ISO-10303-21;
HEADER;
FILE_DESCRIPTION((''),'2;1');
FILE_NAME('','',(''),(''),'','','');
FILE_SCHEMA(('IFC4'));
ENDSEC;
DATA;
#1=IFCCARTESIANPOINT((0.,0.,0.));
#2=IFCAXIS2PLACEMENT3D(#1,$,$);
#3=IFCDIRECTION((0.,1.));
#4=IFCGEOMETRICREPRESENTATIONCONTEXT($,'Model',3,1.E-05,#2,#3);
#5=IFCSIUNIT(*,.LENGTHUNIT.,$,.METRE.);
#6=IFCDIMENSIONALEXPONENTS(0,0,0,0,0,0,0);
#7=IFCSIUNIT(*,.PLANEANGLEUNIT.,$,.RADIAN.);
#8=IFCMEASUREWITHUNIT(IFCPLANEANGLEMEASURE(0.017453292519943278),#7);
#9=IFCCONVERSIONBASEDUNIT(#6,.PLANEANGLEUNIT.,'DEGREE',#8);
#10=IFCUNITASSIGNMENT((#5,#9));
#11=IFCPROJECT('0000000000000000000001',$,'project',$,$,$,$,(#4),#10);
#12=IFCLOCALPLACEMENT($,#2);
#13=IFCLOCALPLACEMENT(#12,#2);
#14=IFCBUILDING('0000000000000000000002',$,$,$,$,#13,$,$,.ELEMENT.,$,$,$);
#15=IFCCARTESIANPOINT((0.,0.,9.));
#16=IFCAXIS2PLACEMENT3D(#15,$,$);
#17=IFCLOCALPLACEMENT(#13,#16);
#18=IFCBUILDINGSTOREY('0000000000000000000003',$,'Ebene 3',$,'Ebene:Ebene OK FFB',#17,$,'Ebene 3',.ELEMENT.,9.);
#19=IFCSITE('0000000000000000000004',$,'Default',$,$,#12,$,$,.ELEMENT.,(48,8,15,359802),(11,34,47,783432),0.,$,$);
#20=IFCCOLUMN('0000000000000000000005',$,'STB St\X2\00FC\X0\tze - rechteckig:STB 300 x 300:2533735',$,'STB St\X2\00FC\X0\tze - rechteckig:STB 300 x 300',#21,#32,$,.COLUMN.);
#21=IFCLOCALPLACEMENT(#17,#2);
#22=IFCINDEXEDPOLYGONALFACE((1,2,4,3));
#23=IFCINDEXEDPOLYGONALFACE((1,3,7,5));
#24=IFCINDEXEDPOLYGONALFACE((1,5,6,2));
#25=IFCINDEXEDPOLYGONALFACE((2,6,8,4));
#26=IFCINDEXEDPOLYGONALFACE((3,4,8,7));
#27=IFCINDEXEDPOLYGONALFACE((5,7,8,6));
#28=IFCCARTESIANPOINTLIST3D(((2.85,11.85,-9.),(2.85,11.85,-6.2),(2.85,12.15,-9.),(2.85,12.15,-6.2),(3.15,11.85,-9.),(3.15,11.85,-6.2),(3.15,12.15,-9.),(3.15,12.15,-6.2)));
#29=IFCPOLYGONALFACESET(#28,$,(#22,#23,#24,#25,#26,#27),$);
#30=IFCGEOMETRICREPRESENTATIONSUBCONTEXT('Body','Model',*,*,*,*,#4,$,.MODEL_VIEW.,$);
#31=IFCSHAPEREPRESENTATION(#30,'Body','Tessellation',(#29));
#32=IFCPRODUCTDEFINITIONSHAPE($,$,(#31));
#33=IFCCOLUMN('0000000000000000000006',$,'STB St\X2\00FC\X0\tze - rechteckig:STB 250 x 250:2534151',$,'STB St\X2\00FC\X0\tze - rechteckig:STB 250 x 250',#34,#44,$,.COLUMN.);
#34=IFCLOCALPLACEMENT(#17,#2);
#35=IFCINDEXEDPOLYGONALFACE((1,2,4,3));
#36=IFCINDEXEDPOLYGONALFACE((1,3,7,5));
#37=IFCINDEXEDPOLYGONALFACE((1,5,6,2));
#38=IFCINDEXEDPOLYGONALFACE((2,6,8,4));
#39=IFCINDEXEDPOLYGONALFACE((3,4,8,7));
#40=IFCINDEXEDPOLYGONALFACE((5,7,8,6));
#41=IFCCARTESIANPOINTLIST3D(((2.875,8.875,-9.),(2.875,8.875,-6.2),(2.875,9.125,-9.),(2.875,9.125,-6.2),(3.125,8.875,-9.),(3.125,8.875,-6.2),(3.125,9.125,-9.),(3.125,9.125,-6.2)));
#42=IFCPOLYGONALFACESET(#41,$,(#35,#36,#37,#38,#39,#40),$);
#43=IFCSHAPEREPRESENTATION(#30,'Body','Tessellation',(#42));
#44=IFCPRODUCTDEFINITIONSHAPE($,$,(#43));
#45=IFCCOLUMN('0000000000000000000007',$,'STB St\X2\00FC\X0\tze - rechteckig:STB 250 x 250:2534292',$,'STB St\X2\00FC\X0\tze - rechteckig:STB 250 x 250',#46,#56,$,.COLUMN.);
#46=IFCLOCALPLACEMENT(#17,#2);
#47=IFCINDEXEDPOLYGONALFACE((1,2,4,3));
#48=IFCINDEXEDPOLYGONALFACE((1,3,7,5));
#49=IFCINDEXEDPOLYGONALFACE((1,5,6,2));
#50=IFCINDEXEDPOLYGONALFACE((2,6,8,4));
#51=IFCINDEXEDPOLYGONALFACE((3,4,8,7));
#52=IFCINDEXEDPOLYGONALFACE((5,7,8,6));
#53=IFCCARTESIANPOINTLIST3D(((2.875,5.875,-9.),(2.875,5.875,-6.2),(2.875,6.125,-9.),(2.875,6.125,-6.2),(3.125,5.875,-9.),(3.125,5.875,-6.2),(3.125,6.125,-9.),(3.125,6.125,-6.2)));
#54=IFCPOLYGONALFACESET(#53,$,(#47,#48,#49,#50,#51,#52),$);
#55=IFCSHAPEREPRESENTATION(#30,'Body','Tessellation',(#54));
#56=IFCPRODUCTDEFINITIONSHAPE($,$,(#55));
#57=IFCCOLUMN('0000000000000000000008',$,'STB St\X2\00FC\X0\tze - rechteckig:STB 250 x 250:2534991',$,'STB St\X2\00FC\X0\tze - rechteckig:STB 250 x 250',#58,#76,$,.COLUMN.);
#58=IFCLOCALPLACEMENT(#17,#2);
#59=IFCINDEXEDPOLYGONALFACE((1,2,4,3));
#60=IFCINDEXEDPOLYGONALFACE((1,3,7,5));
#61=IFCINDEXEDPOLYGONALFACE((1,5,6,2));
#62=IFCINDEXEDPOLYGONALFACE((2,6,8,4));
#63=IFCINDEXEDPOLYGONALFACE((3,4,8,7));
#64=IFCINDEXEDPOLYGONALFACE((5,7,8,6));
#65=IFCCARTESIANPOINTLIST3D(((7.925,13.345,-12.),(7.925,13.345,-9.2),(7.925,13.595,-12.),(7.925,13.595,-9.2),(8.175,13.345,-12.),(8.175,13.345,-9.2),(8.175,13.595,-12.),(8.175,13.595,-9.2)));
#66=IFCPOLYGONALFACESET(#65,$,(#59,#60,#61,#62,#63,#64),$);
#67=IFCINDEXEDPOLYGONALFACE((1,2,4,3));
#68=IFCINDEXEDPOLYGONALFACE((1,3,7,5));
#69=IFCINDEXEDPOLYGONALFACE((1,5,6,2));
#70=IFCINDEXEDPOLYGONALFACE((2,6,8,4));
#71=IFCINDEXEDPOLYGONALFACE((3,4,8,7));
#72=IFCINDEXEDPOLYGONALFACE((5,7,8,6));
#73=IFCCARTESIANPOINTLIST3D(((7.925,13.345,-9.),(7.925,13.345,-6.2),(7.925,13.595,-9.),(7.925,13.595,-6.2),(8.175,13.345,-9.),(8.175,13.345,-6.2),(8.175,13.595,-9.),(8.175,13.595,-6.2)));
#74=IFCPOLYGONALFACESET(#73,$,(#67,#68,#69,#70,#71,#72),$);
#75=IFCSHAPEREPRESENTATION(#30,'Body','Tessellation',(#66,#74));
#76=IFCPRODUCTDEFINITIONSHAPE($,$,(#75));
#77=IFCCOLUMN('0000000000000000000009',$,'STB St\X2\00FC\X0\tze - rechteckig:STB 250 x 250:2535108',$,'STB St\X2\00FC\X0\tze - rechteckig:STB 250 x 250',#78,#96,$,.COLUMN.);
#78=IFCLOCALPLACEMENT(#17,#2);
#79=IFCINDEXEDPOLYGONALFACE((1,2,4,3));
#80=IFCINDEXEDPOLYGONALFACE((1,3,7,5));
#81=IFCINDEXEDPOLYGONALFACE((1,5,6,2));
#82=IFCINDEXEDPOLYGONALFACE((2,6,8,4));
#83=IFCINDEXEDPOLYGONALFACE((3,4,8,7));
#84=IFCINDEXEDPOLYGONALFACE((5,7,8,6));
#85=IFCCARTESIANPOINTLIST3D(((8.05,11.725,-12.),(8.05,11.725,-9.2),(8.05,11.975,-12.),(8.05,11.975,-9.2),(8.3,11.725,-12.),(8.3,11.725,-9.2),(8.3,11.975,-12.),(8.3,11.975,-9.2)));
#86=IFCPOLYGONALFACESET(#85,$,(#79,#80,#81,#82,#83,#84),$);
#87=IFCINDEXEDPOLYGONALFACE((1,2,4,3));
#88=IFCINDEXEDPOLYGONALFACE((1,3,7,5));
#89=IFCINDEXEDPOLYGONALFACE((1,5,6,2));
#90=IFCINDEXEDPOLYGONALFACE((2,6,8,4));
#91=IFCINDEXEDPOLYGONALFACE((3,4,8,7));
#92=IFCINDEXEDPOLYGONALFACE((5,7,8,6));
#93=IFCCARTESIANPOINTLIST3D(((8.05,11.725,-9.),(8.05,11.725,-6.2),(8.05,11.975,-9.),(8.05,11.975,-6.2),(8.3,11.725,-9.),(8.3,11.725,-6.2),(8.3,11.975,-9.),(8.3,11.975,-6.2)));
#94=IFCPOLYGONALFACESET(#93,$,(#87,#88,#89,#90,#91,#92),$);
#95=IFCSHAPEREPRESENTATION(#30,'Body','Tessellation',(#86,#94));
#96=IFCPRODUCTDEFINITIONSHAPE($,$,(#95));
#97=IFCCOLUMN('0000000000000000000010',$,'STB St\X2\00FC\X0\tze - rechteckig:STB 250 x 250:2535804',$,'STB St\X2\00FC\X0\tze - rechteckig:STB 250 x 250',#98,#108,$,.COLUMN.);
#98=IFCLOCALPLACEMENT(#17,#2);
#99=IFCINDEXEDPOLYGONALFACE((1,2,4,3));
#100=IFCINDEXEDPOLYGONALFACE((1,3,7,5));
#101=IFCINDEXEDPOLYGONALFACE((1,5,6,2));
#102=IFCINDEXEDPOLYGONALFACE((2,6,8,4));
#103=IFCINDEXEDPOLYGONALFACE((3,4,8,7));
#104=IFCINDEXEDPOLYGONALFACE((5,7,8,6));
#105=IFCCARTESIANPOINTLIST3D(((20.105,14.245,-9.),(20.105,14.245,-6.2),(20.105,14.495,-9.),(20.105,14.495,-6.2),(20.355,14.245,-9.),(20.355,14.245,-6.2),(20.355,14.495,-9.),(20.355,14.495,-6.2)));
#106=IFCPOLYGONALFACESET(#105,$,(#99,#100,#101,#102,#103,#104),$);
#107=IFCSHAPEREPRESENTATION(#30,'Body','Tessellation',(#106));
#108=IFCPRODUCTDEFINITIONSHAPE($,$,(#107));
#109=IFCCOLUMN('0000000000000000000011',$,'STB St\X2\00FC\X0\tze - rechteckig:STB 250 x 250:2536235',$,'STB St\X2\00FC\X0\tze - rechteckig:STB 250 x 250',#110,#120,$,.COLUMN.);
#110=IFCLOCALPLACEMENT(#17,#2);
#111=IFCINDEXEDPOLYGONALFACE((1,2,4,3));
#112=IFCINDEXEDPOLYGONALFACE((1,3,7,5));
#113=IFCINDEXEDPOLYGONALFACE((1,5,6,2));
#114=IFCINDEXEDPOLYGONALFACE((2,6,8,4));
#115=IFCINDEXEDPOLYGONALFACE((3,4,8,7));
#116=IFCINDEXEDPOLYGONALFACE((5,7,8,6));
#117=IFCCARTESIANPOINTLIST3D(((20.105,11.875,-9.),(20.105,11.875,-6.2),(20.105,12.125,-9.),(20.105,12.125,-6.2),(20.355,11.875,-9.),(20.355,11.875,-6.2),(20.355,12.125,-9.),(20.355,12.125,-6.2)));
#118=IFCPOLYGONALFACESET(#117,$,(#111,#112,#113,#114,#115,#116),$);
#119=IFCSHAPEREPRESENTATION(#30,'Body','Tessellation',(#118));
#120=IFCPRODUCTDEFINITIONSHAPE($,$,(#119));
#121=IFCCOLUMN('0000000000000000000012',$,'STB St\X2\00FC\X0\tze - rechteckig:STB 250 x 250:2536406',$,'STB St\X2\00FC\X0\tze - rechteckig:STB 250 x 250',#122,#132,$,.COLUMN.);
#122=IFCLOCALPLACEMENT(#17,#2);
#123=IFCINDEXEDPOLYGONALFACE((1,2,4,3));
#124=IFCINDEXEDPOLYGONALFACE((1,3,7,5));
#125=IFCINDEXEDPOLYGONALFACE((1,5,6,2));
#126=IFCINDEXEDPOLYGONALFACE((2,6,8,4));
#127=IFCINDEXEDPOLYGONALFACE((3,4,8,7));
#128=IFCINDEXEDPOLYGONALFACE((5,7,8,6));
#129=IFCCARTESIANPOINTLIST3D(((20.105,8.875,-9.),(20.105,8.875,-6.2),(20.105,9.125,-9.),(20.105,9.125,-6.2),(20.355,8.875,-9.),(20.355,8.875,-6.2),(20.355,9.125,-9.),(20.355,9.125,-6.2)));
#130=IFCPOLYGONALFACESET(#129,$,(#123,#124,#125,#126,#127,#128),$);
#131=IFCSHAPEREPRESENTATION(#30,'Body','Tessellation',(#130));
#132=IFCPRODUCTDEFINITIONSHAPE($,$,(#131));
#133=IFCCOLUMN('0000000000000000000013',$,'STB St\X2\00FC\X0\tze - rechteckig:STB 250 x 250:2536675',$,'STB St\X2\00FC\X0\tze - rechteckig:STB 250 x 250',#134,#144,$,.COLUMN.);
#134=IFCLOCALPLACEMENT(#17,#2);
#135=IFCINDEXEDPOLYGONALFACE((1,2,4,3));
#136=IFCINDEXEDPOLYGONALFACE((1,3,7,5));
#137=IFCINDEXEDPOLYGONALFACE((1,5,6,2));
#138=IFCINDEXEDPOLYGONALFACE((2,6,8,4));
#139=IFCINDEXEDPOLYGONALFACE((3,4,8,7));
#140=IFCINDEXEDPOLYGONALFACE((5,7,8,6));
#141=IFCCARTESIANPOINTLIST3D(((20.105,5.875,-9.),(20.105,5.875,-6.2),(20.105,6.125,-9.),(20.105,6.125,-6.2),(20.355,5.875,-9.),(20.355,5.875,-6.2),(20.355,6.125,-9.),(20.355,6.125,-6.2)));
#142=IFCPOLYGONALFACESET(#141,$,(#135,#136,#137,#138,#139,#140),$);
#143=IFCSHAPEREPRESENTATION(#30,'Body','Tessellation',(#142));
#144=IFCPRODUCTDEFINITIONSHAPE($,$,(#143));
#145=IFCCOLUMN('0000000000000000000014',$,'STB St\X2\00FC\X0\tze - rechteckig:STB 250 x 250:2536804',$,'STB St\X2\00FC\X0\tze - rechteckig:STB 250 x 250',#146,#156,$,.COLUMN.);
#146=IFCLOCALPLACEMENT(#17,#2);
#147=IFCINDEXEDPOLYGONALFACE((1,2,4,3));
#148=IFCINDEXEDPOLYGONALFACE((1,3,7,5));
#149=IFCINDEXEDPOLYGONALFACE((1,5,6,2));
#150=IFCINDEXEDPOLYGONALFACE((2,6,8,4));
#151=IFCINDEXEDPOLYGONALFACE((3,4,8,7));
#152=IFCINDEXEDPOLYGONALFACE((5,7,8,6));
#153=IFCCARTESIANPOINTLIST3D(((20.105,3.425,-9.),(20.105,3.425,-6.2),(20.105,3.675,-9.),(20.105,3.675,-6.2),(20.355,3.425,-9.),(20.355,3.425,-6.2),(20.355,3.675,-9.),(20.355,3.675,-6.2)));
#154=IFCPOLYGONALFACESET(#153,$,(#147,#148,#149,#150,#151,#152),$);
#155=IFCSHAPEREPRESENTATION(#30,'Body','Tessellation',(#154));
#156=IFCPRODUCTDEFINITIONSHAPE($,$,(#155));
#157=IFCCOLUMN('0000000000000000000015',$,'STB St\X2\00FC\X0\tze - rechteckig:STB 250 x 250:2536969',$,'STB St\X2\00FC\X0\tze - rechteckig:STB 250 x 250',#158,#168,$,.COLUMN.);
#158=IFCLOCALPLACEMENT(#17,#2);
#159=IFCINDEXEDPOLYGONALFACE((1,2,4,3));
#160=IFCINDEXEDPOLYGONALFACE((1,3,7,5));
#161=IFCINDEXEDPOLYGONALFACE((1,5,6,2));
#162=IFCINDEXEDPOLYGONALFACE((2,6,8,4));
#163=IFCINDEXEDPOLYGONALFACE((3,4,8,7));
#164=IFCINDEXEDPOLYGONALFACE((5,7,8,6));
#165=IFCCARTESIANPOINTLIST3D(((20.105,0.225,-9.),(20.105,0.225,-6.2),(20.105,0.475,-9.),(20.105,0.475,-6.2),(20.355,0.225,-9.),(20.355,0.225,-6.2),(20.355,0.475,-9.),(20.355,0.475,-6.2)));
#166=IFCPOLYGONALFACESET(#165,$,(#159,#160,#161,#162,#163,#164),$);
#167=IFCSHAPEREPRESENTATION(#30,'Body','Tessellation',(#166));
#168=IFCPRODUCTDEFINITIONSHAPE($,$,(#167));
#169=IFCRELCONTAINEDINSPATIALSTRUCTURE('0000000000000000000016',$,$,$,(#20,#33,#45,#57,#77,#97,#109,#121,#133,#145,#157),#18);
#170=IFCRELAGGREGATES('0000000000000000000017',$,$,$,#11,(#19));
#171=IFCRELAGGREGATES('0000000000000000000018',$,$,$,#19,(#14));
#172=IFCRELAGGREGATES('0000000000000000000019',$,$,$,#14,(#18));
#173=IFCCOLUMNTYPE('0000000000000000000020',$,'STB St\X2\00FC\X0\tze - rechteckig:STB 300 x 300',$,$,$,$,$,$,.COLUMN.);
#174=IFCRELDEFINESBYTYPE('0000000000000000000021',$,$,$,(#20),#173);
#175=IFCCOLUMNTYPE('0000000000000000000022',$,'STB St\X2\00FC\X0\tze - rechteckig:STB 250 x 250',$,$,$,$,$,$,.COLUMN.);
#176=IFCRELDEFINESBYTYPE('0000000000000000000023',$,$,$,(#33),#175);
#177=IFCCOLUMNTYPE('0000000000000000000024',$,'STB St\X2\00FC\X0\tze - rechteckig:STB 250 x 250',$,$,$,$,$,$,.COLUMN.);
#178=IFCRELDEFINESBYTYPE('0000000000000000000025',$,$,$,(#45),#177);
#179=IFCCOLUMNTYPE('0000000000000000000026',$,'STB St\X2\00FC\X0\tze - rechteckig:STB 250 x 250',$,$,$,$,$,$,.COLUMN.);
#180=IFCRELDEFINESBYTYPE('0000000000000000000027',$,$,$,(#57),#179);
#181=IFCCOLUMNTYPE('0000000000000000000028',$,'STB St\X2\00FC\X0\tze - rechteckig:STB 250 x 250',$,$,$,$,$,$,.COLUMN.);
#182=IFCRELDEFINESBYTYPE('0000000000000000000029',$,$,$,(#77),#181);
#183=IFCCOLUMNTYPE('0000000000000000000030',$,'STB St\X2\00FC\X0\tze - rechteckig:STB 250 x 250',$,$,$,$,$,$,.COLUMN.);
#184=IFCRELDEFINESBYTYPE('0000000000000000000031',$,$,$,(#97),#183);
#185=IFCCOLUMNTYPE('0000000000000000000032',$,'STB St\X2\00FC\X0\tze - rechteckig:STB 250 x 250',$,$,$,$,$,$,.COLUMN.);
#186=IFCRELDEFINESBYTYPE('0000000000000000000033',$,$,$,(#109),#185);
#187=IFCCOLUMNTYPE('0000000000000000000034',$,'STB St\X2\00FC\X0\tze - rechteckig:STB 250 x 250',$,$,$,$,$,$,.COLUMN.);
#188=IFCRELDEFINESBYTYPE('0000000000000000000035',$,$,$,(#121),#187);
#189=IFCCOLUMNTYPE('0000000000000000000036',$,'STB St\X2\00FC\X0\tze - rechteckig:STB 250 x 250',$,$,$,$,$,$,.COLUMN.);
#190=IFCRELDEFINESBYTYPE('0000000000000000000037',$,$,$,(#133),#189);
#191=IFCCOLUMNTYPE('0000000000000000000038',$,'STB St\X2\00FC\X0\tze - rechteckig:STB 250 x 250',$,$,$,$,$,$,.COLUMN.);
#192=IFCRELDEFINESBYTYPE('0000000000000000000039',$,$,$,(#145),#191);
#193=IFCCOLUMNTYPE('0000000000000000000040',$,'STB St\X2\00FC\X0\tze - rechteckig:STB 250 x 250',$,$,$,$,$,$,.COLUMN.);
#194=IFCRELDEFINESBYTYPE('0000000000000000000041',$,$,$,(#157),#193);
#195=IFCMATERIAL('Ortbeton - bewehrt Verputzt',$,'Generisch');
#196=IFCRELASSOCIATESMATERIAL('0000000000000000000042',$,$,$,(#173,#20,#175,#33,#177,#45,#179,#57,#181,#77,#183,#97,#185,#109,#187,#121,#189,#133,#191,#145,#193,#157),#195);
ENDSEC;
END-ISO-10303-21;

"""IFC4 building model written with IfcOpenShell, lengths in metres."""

from ifc_helpers import new_model, entity, si_unit, converted_unit, direction, frame, origin, place, context, subcontext, project, spatial, indexed_curve, outline, extrude, source, transform, mapped, material, type_object, type_shapes, element, save


model = new_model("IFC4")

# Units and contexts
model_context = context("Model", 3, precision=1e-05, world=origin(), true_north=direction((0.0, 1.0)))
body_context = subcontext(model_context, "Body", "Model", "MODEL_VIEW")
ifc_project = project(units=[si_unit("LENGTHUNIT", "METRE"), converted_unit("PLANEANGLEUNIT", "DEGREE", entity("IfcPlaneAngleMeasure", 0.017453292519943278), si_unit("PLANEANGLEUNIT", "RADIAN"), dimensions=[0, 0, 0, 0, 0, 0, 0])], contexts=[model_context])

# Site, building, storey
site_placement = place(None, origin())
site = spatial("IfcSite", under=ifc_project, at=site_placement, Name="Default", CompositionType="ELEMENT", RefLatitude=(48, 8, 15, 359802), RefLongitude=(11, 34, 47, 783432), RefElevation=0.0)
building_placement = place(site_placement, origin())
building = spatial("IfcBuilding", under=site, at=building_placement, CompositionType="ELEMENT")
storey_placement = place(building_placement, frame((0.0, 0.0, 9.0)))
storey = spatial("IfcBuildingStorey", under=building, at=storey_placement, Name="Ebene 3", ObjectType="Ebene:Ebene OK FFB", LongName="Ebene 3", CompositionType="ELEMENT", Elevation=9.0)

# Columns
ifc_material_1 = material(Name="Ortbeton - bewehrt Verputzt", Category="Generisch")
column_type_1 = type_object("IfcColumnType", Name="STB Stütze - rechteckig:STB 300 x 300", PredefinedType="COLUMN", material=ifc_material_1)
shared_shape_1 = source(origin(), body_context, "Body", "SweptSolid", [
    extrude(outline(indexed_curve([(-0.15, -0.15), (0.15, -0.15), (0.15, 0.15), (-0.15, 0.15), (-0.15, -0.15)], self_intersect=False)), frame((3.0, 12.0, 0.0), z_axis=(0.0, 0.0, 1.0), x_axis=(-1.0, 0.0, 0.0)), (0.0, 0.0, 1.0), 2.8),
])
type_shapes(column_type_1, [shared_shape_1])
column_1_placement = place(storey_placement, frame((0.0, 0.0, -9.0)))
element("IfcColumn", 1, at=column_1_placement, inside=storey, type_object=column_type_1, material=ifc_material_1, Name="STB Stütze - rechteckig:STB 300 x 300:2533735", ObjectType="STB Stütze - rechteckig:STB 300 x 300", PredefinedType="COLUMN", context=body_context, shape_type="MappedRepresentation", body=[
    mapped(shared_shape_1, transform((0.0, 0.0, 0.0), scale=1.0)),
])
column_type_2 = type_object("IfcColumnType", Name="STB Stütze - rechteckig:STB 250 x 250", PredefinedType="COLUMN", material=ifc_material_1)
shared_shape_2 = source(origin(), body_context, "Body", "SweptSolid", [
    extrude(outline(indexed_curve([(-0.125, -0.125), (0.125, -0.125), (0.125, 0.125), (-0.125, 0.125), (-0.125, -0.125)], self_intersect=False)), frame((3.0, 9.0, 0.0), z_axis=(0.0, 0.0, 1.0), x_axis=(-1.0, 0.0, 0.0)), (0.0, 0.0, 1.0), 2.8),
])
type_shapes(column_type_2, [shared_shape_2])
column_2_placement = place(storey_placement, frame((0.0, 0.0, -9.0)))
element("IfcColumn", 2, at=column_2_placement, inside=storey, type_object=column_type_2, material=ifc_material_1, Name="STB Stütze - rechteckig:STB 250 x 250:2534151", ObjectType="STB Stütze - rechteckig:STB 250 x 250", PredefinedType="COLUMN", context=body_context, shape_type="MappedRepresentation", body=[
    mapped(shared_shape_2, transform((0.0, 0.0, 0.0), scale=1.0)),
])
column_type_3 = type_object("IfcColumnType", Name="STB Stütze - rechteckig:STB 250 x 250", PredefinedType="COLUMN", material=ifc_material_1)
shared_shape_3 = source(origin(), body_context, "Body", "SweptSolid", [
    extrude(outline(indexed_curve([(-0.125, -0.125), (0.125, -0.125), (0.125, 0.125), (-0.125, 0.125), (-0.125, -0.125)], self_intersect=False)), frame((3.0, 6.0, 0.0), z_axis=(0.0, 0.0, 1.0), x_axis=(-1.0, 0.0, 0.0)), (0.0, 0.0, 1.0), 2.8),
])
type_shapes(column_type_3, [shared_shape_3])
column_3_placement = place(storey_placement, frame((0.0, 0.0, -9.0)))
element("IfcColumn", 3, at=column_3_placement, inside=storey, type_object=column_type_3, material=ifc_material_1, Name="STB Stütze - rechteckig:STB 250 x 250:2534292", ObjectType="STB Stütze - rechteckig:STB 250 x 250", PredefinedType="COLUMN", context=body_context, shape_type="MappedRepresentation", body=[
    mapped(shared_shape_3, transform((0.0, 0.0, 0.0), scale=1.0)),
])
column_type_4 = type_object("IfcColumnType", Name="STB Stütze - rechteckig:STB 250 x 250", PredefinedType="COLUMN", material=ifc_material_1)
shared_shape_4 = source(origin(), body_context, "Body", "SweptSolid", [
    extrude(outline(indexed_curve([(-0.125, -0.125), (0.125, -0.125), (0.125, 0.125), (-0.125, 0.125), (-0.125, -0.125)], self_intersect=False)), frame((8.05, 13.47, -3.0), z_axis=(0.0, 0.0, 1.0), x_axis=(-1.0, 0.0, 0.0)), (0.0, 0.0, 1.0), 2.8),
    extrude(outline(indexed_curve([(-0.125, -0.125), (0.125, -0.125), (0.125, 0.125), (-0.125, 0.125), (-0.125, -0.125)], self_intersect=False)), frame((8.05, 13.47, 0.0), z_axis=(0.0, 0.0, 1.0), x_axis=(0.0, -1.0, 0.0)), (0.0, 0.0, 1.0), 2.8),
])
type_shapes(column_type_4, [shared_shape_4])
column_4_placement = place(storey_placement, frame((0.0, 0.0, -9.0)))
element("IfcColumn", 4, at=column_4_placement, inside=storey, type_object=column_type_4, material=ifc_material_1, Name="STB Stütze - rechteckig:STB 250 x 250:2534991", ObjectType="STB Stütze - rechteckig:STB 250 x 250", PredefinedType="COLUMN", context=body_context, shape_type="MappedRepresentation", body=[
    mapped(shared_shape_4, transform((0.0, 0.0, 0.0), scale=1.0)),
])
column_type_5 = type_object("IfcColumnType", Name="STB Stütze - rechteckig:STB 250 x 250", PredefinedType="COLUMN", material=ifc_material_1)
shared_shape_5 = source(origin(), body_context, "Body", "SweptSolid", [
    extrude(outline(indexed_curve([(-0.125, -0.125), (0.125, -0.125), (0.125, 0.125), (-0.125, 0.125), (-0.125, -0.125)], self_intersect=False)), frame((8.175, 11.85, -3.0), z_axis=(0.0, 0.0, 1.0), x_axis=(-1.0, 0.0, 0.0)), (0.0, 0.0, 1.0), 2.8),
    extrude(outline(indexed_curve([(-0.125, -0.125), (0.125, -0.125), (0.125, 0.125), (-0.125, 0.125), (-0.125, -0.125)], self_intersect=False)), frame((8.175, 11.85, 0.0), z_axis=(0.0, 0.0, 1.0), x_axis=(0.0, -1.0, 0.0)), (0.0, 0.0, 1.0), 2.8),
])
type_shapes(column_type_5, [shared_shape_5])
column_5_placement = place(storey_placement, frame((0.0, 0.0, -9.0)))
element("IfcColumn", 5, at=column_5_placement, inside=storey, type_object=column_type_5, material=ifc_material_1, Name="STB Stütze - rechteckig:STB 250 x 250:2535108", ObjectType="STB Stütze - rechteckig:STB 250 x 250", PredefinedType="COLUMN", context=body_context, shape_type="MappedRepresentation", body=[
    mapped(shared_shape_5, transform((0.0, 0.0, 0.0), scale=1.0)),
])
column_type_6 = type_object("IfcColumnType", Name="STB Stütze - rechteckig:STB 250 x 250", PredefinedType="COLUMN", material=ifc_material_1)
shared_shape_6 = source(origin(), body_context, "Body", "SweptSolid", [
    extrude(outline(indexed_curve([(-0.125, -0.125), (0.125, -0.125), (0.125, 0.125), (-0.125, 0.125), (-0.125, -0.125)], self_intersect=False)), frame((20.23, 14.37, 0.0), z_axis=(0.0, 0.0, 1.0), x_axis=(-1.0, 0.0, 0.0)), (0.0, 0.0, 1.0), 2.8),
])
type_shapes(column_type_6, [shared_shape_6])
column_6_placement = place(storey_placement, frame((0.0, 0.0, -9.0)))
element("IfcColumn", 6, at=column_6_placement, inside=storey, type_object=column_type_6, material=ifc_material_1, Name="STB Stütze - rechteckig:STB 250 x 250:2535804", ObjectType="STB Stütze - rechteckig:STB 250 x 250", PredefinedType="COLUMN", context=body_context, shape_type="MappedRepresentation", body=[
    mapped(shared_shape_6, transform((0.0, 0.0, 0.0), scale=1.0)),
])
column_type_7 = type_object("IfcColumnType", Name="STB Stütze - rechteckig:STB 250 x 250", PredefinedType="COLUMN", material=ifc_material_1)
shared_shape_7 = source(origin(), body_context, "Body", "SweptSolid", [
    extrude(outline(indexed_curve([(-0.125, -0.125), (0.125, -0.125), (0.125, 0.125), (-0.125, 0.125), (-0.125, -0.125)], self_intersect=False)), frame((20.23, 12.0, 0.0), z_axis=(0.0, 0.0, 1.0), x_axis=(-1.0, 0.0, 0.0)), (0.0, 0.0, 1.0), 2.8),
])
type_shapes(column_type_7, [shared_shape_7])
column_7_placement = place(storey_placement, frame((0.0, 0.0, -9.0)))
element("IfcColumn", 7, at=column_7_placement, inside=storey, type_object=column_type_7, material=ifc_material_1, Name="STB Stütze - rechteckig:STB 250 x 250:2536235", ObjectType="STB Stütze - rechteckig:STB 250 x 250", PredefinedType="COLUMN", context=body_context, shape_type="MappedRepresentation", body=[
    mapped(shared_shape_7, transform((0.0, 0.0, 0.0), scale=1.0)),
])
column_type_8 = type_object("IfcColumnType", Name="STB Stütze - rechteckig:STB 250 x 250", PredefinedType="COLUMN", material=ifc_material_1)
shared_shape_8 = source(origin(), body_context, "Body", "SweptSolid", [
    extrude(outline(indexed_curve([(-0.125, -0.125), (0.125, -0.125), (0.125, 0.125), (-0.125, 0.125), (-0.125, -0.125)], self_intersect=False)), frame((20.23, 9.0, 0.0), z_axis=(0.0, 0.0, 1.0), x_axis=(-1.0, 0.0, 0.0)), (0.0, 0.0, 1.0), 2.8),
])
type_shapes(column_type_8, [shared_shape_8])
column_8_placement = place(storey_placement, frame((0.0, 0.0, -9.0)))
element("IfcColumn", 8, at=column_8_placement, inside=storey, type_object=column_type_8, material=ifc_material_1, Name="STB Stütze - rechteckig:STB 250 x 250:2536406", ObjectType="STB Stütze - rechteckig:STB 250 x 250", PredefinedType="COLUMN", context=body_context, shape_type="MappedRepresentation", body=[
    mapped(shared_shape_8, transform((0.0, 0.0, 0.0), scale=1.0)),
])
column_type_9 = type_object("IfcColumnType", Name="STB Stütze - rechteckig:STB 250 x 250", PredefinedType="COLUMN", material=ifc_material_1)
shared_shape_9 = source(origin(), body_context, "Body", "SweptSolid", [
    extrude(outline(indexed_curve([(-0.125, -0.125), (0.125, -0.125), (0.125, 0.125), (-0.125, 0.125), (-0.125, -0.125)], self_intersect=False)), frame((20.23, 6.0, 0.0), z_axis=(0.0, 0.0, 1.0), x_axis=(-1.0, 0.0, 0.0)), (0.0, 0.0, 1.0), 2.8),
])
type_shapes(column_type_9, [shared_shape_9])
column_9_placement = place(storey_placement, frame((0.0, 0.0, -9.0)))
element("IfcColumn", 9, at=column_9_placement, inside=storey, type_object=column_type_9, material=ifc_material_1, Name="STB Stütze - rechteckig:STB 250 x 250:2536675", ObjectType="STB Stütze - rechteckig:STB 250 x 250", PredefinedType="COLUMN", context=body_context, shape_type="MappedRepresentation", body=[
    mapped(shared_shape_9, transform((0.0, 0.0, 0.0), scale=1.0)),
])
column_type_10 = type_object("IfcColumnType", Name="STB Stütze - rechteckig:STB 250 x 250", PredefinedType="COLUMN", material=ifc_material_1)
shared_shape_10 = source(origin(), body_context, "Body", "SweptSolid", [
    extrude(outline(indexed_curve([(-0.125, -0.125), (0.125, -0.125), (0.125, 0.125), (-0.125, 0.125), (-0.125, -0.125)], self_intersect=False)), frame((20.23, 3.55, 0.0), z_axis=(0.0, 0.0, 1.0), x_axis=(-1.0, 0.0, 0.0)), (0.0, 0.0, 1.0), 2.8),
])
type_shapes(column_type_10, [shared_shape_10])
column_10_placement = place(storey_placement, frame((0.0, 0.0, -9.0)))
element("IfcColumn", 10, at=column_10_placement, inside=storey, type_object=column_type_10, material=ifc_material_1, Name="STB Stütze - rechteckig:STB 250 x 250:2536804", ObjectType="STB Stütze - rechteckig:STB 250 x 250", PredefinedType="COLUMN", context=body_context, shape_type="MappedRepresentation", body=[
    mapped(shared_shape_10, transform((0.0, 0.0, 0.0), scale=1.0)),
])
column_type_11 = type_object("IfcColumnType", Name="STB Stütze - rechteckig:STB 250 x 250", PredefinedType="COLUMN", material=ifc_material_1)
shared_shape_11 = source(origin(), body_context, "Body", "SweptSolid", [
    extrude(outline(indexed_curve([(-0.125, -0.125), (0.125, -0.125), (0.125, 0.125), (-0.125, 0.125), (-0.125, -0.125)], self_intersect=False)), frame((20.23, 0.35, 0.0), z_axis=(0.0, 0.0, 1.0), x_axis=(-1.0, 0.0, 0.0)), (0.0, 0.0, 1.0), 2.8),
])
type_shapes(column_type_11, [shared_shape_11])
column_11_placement = place(storey_placement, frame((0.0, 0.0, -9.0)))
element("IfcColumn", 11, at=column_11_placement, inside=storey, type_object=column_type_11, material=ifc_material_1, Name="STB Stütze - rechteckig:STB 250 x 250:2536969", ObjectType="STB Stütze - rechteckig:STB 250 x 250", PredefinedType="COLUMN", context=body_context, shape_type="MappedRepresentation", body=[
    mapped(shared_shape_11, transform((0.0, 0.0, 0.0), scale=1.0)),
])

save(model, "model.ifc")
